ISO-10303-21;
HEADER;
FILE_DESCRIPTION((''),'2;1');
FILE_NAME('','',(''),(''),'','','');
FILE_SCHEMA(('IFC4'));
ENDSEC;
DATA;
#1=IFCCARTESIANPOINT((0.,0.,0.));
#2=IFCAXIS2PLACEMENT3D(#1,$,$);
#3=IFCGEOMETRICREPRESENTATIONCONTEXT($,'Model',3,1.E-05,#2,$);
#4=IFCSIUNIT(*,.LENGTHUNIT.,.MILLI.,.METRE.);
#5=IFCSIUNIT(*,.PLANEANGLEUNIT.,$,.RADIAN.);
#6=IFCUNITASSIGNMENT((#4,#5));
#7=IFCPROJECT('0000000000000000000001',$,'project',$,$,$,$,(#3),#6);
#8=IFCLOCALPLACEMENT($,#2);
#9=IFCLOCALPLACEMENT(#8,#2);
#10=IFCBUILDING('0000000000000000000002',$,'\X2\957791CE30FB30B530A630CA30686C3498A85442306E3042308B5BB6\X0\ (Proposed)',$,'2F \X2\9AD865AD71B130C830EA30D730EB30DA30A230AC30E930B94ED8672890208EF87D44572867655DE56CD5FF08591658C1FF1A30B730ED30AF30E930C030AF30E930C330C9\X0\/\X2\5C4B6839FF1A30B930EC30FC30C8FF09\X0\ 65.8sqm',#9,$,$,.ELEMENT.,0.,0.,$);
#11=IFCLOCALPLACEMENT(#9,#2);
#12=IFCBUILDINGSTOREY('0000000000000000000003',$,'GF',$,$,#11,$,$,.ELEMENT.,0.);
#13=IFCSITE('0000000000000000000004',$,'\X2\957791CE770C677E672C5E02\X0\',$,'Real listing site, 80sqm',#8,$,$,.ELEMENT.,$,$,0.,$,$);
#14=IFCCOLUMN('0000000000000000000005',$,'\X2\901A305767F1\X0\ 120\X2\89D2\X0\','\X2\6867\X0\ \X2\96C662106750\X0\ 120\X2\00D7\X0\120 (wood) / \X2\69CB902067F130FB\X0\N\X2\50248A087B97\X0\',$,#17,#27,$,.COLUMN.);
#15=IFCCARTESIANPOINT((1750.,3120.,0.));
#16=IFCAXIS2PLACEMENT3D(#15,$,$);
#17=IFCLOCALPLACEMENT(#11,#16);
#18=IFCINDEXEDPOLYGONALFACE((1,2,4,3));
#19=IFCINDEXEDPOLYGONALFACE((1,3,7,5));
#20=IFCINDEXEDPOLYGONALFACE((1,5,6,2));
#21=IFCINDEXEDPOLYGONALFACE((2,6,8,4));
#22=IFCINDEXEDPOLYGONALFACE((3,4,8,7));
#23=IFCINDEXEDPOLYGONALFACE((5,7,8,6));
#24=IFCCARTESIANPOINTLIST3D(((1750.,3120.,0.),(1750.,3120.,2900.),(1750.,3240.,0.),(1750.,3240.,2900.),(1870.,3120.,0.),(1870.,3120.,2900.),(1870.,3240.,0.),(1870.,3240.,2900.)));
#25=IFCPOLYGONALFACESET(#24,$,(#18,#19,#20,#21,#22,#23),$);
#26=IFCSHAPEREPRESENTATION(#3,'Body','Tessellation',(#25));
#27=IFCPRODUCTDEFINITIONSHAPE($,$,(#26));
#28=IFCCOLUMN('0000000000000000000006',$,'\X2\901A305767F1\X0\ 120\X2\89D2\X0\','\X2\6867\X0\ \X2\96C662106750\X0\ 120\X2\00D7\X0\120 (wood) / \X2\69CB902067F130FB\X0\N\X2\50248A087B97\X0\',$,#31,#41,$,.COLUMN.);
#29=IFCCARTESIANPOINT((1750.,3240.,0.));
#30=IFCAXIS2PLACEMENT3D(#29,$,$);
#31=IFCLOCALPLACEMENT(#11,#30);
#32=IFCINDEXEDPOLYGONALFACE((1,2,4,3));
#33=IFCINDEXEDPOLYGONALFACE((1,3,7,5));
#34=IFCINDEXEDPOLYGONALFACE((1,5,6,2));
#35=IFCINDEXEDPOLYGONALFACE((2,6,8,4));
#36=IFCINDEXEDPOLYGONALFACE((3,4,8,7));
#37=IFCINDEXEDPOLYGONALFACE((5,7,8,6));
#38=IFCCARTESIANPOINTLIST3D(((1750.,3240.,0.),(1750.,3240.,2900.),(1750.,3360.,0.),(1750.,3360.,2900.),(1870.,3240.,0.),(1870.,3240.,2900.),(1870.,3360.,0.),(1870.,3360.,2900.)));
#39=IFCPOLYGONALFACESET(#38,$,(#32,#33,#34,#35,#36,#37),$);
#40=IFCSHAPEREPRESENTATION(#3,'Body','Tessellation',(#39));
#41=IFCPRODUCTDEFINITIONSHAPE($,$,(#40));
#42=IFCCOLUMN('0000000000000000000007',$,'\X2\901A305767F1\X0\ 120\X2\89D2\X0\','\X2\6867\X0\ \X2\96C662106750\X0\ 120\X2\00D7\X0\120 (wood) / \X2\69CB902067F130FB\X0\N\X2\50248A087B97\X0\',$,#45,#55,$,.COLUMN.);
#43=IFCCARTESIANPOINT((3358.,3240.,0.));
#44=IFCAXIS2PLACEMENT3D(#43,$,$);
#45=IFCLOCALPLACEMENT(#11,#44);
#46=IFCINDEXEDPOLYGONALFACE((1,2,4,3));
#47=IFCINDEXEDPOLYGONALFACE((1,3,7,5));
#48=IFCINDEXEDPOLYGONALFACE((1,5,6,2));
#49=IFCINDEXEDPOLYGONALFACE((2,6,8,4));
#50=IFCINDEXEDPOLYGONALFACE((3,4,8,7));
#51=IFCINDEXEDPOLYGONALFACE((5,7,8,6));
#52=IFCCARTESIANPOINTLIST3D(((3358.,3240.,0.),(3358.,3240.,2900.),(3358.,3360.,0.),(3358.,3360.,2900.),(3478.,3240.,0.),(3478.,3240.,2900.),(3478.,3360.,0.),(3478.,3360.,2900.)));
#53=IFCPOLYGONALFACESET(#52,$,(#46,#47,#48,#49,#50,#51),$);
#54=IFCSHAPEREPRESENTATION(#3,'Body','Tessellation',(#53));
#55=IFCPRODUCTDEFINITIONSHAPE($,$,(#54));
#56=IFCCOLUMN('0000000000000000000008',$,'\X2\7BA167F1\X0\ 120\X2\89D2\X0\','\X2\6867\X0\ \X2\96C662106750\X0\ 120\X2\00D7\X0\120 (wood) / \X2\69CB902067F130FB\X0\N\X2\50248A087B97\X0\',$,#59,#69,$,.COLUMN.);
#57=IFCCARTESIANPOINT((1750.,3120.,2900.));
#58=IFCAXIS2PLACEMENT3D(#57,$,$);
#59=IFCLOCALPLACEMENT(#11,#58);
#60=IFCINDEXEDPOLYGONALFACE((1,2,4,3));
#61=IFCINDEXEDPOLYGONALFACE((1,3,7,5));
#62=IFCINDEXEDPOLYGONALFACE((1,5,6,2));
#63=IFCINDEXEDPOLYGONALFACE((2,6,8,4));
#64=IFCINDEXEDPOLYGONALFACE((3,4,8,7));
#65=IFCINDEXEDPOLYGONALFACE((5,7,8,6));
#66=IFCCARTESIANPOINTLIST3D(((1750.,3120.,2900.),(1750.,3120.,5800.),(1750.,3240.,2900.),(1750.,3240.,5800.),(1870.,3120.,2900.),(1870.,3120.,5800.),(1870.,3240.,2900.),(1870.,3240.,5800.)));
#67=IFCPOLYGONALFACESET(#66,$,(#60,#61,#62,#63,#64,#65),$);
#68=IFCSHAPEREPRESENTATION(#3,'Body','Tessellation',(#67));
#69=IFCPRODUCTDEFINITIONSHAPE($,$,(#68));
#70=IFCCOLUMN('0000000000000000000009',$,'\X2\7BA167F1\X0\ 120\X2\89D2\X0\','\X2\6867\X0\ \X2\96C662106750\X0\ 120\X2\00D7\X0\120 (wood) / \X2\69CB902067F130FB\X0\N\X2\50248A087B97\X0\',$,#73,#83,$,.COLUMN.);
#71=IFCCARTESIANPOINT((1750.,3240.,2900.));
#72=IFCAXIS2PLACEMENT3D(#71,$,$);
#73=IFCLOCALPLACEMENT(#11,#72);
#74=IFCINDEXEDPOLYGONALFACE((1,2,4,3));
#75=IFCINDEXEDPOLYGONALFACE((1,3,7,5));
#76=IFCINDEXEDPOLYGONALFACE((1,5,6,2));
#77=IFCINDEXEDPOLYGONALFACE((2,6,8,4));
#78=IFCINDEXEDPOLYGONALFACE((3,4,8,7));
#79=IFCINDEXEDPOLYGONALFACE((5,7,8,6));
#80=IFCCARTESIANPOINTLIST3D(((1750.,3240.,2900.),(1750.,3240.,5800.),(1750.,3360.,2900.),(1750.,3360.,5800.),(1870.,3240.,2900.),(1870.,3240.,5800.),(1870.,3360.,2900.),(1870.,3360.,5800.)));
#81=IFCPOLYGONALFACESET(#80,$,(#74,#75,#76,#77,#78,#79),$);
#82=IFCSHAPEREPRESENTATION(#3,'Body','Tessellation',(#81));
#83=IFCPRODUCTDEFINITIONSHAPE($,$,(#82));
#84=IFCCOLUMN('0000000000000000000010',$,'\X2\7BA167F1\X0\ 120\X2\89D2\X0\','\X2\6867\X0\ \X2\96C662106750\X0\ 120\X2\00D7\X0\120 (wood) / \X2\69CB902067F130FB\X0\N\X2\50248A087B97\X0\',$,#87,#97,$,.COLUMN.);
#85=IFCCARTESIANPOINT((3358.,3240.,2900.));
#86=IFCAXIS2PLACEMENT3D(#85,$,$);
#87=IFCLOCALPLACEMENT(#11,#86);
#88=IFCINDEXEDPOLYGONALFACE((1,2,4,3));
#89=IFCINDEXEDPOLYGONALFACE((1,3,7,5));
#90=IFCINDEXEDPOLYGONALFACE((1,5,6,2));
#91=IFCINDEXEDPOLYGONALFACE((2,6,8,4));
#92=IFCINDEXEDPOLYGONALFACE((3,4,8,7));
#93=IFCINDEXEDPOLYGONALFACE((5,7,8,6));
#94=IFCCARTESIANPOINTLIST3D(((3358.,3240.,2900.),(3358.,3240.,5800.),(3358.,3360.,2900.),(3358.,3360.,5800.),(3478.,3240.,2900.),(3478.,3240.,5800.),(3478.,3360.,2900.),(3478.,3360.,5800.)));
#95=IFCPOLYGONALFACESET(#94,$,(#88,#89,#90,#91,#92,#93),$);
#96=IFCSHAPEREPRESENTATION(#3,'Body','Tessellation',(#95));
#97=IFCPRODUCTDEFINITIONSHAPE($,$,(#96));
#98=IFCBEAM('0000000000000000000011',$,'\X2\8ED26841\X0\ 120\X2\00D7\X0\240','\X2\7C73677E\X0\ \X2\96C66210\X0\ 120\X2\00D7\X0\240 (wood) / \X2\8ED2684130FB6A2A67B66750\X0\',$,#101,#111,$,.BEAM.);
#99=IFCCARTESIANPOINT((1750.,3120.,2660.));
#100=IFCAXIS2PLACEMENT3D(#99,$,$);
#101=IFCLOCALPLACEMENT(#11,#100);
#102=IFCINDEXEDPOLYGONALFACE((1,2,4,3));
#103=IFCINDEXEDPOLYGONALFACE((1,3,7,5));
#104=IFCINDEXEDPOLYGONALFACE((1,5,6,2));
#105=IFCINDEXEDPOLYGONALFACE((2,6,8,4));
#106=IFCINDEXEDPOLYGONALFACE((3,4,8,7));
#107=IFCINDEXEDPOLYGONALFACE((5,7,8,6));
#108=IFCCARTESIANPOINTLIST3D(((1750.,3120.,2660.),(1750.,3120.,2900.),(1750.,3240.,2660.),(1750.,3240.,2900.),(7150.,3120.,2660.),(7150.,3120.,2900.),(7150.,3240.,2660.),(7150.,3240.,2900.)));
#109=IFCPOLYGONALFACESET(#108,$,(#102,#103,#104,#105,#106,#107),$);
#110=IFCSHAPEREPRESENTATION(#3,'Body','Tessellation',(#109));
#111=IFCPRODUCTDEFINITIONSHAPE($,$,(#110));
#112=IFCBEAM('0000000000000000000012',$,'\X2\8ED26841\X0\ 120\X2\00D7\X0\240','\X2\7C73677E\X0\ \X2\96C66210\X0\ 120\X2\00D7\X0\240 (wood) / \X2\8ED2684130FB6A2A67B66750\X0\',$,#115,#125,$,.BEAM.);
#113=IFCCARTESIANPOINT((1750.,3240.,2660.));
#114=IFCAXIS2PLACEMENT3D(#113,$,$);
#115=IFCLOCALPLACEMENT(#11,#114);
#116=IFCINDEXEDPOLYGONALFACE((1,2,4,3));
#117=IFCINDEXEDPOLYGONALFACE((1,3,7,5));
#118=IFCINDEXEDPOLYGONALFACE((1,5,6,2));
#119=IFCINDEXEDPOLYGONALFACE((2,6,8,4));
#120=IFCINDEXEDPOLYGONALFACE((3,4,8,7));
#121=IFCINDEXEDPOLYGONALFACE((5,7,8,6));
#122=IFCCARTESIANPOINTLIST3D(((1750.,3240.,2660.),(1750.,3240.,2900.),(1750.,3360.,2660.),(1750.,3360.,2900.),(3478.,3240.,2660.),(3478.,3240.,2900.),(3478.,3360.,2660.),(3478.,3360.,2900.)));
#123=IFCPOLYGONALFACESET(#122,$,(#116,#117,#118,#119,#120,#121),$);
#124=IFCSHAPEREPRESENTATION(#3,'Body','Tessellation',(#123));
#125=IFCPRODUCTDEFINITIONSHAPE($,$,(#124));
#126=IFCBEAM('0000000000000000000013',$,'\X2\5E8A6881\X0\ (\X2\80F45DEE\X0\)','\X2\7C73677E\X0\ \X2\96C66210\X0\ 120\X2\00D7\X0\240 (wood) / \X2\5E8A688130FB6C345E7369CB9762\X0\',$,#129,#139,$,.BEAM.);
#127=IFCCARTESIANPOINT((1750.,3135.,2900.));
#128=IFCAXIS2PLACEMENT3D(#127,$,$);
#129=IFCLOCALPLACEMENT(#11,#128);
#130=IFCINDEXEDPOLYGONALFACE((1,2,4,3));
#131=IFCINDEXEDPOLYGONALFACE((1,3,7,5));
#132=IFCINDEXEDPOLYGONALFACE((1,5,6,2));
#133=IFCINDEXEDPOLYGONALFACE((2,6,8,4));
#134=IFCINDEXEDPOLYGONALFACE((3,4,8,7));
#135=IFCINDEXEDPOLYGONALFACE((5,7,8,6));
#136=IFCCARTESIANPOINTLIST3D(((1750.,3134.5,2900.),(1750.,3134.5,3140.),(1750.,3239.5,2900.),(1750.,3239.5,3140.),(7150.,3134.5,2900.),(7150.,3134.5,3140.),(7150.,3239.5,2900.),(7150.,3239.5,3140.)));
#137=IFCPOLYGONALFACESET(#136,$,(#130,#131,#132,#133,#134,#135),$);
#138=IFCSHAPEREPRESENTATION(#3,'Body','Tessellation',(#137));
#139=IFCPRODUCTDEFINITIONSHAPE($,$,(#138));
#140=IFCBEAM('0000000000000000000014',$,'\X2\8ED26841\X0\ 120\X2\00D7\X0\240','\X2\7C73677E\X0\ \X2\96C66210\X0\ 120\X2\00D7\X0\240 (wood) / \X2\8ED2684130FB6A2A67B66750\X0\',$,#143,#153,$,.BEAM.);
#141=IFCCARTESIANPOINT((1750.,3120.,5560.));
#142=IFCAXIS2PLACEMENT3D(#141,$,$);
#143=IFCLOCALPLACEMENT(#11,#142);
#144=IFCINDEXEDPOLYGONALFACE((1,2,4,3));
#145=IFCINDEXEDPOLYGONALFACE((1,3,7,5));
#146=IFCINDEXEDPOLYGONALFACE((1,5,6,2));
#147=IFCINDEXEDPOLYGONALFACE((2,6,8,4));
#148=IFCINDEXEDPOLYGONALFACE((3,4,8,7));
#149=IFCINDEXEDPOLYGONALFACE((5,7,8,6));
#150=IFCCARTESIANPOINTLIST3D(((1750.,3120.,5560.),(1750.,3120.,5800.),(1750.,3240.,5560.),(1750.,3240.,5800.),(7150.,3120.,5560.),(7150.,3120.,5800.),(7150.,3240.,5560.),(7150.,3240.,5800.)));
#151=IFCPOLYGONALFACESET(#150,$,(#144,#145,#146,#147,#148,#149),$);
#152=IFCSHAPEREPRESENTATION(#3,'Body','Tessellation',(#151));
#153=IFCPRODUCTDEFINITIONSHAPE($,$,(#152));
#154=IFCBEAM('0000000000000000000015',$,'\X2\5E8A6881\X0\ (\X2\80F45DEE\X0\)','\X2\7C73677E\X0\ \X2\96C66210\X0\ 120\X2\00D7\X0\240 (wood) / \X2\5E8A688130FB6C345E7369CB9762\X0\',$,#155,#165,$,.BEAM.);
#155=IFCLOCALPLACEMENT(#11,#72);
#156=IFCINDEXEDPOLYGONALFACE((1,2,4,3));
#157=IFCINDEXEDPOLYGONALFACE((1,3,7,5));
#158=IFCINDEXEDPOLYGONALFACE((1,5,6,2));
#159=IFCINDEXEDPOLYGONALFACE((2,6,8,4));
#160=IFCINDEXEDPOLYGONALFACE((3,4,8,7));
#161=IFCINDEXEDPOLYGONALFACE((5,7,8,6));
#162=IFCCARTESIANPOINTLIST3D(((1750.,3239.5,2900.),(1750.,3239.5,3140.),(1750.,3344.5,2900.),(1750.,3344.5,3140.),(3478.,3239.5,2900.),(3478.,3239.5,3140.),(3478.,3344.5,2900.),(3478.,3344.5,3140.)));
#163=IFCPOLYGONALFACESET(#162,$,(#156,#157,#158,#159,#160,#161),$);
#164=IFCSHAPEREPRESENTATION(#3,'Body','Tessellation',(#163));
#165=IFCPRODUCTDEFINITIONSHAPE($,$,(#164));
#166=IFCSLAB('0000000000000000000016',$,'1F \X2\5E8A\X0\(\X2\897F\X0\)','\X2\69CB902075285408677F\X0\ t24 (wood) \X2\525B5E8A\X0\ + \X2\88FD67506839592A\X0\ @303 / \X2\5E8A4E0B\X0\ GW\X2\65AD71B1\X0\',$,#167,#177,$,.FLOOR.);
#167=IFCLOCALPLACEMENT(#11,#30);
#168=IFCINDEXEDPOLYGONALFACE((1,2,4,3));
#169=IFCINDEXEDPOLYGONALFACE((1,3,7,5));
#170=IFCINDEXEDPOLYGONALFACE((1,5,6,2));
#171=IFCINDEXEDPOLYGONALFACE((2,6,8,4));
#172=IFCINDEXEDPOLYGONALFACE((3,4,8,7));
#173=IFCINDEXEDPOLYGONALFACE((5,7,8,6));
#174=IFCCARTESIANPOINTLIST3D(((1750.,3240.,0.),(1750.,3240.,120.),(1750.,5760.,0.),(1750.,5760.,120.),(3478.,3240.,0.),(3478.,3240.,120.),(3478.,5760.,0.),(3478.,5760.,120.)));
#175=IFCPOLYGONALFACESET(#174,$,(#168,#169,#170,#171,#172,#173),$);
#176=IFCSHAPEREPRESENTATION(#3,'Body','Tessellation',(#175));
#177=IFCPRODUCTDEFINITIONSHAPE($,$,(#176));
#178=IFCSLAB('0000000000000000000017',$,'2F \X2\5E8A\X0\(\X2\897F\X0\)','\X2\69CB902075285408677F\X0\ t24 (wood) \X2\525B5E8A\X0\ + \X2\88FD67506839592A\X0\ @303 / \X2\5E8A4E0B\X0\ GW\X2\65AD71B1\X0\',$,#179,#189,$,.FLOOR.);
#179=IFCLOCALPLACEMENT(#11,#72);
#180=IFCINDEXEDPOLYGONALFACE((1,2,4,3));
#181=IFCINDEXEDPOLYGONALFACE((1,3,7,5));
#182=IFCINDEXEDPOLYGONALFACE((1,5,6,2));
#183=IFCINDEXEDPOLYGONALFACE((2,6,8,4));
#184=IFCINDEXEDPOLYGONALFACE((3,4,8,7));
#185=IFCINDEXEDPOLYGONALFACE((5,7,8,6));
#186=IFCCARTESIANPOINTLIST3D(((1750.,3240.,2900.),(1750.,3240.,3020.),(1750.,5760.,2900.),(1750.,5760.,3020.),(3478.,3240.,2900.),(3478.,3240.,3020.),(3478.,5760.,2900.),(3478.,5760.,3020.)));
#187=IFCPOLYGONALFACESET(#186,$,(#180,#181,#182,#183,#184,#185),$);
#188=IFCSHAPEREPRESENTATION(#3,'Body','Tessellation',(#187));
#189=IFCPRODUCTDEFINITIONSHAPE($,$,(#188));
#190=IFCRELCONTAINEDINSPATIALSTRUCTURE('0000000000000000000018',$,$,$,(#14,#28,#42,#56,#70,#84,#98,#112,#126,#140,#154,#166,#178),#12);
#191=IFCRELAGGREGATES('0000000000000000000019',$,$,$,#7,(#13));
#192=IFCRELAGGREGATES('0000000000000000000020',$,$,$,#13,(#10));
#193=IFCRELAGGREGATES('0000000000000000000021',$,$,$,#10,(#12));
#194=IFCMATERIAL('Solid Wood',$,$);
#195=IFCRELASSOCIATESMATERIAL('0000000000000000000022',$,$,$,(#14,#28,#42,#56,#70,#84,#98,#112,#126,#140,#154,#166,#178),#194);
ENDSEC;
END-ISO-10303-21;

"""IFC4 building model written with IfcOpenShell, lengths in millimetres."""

from ifc_helpers import new_model, si_unit, frame, frame_2d, origin, place, context, project, spatial, rectangle, extrude, material, element, save


model = new_model("IFC4")

# Units and contexts
model_context = context("Model", 3, precision=1e-05, world=origin())
ifc_project = project(units=[si_unit("LENGTHUNIT", "METRE", prefix="MILLI"), si_unit("PLANEANGLEUNIT", "RADIAN")], contexts=[model_context])

# Site, building, storey
site_placement = place(None, origin())
site = spatial("IfcSite", under=ifc_project, at=site_placement, Name="長野県松本市", ObjectType="Real listing site, 80sqm", CompositionType="ELEMENT", RefElevation=0.0)
building_placement = place(site_placement, origin())
building = spatial("IfcBuilding", under=site, at=building_placement, Name="長野・サウナと水風呂のある家 (Proposed)", ObjectType="2F 高断熱トリプルペアガラス付木造軸組在来工法（外壁：シロクラダクラッド/屋根：スレート） 65.8sqm", CompositionType="ELEMENT", ElevationOfRefHeight=0.0, ElevationOfTerrain=0.0)
storey_placement = place(building_placement, origin())
storey = spatial("IfcBuildingStorey", under=building, at=storey_placement, Name="GF", CompositionType="ELEMENT", Elevation=0.0)

# Columns
ifc_material_1 = material(Name="Solid Wood")
column_1_placement = place(storey_placement, frame((1750.0, 3120.0, 0.0)))
element("IfcColumn", 1, at=column_1_placement, inside=storey, material=ifc_material_1, Name="通し柱 120角", Description="桧 集成材 120×120 (wood) / 構造柱・N値計算", PredefinedType="COLUMN", context=model_context, shape_type="SweptSolid", body=[
    extrude(rectangle(XDim=120.0, YDim=120.0, at=frame_2d((60.0, 60.0))), frame((1750.0, 3120.0, 0.0)), (0.0, 0.0, 1.0), 2900.0),
])
column_2_placement = place(storey_placement, frame((1750.0, 3240.0, 0.0)))
element("IfcColumn", 2, at=column_2_placement, inside=storey, material=ifc_material_1, Name="通し柱 120角", Description="桧 集成材 120×120 (wood) / 構造柱・N値計算", PredefinedType="COLUMN", context=model_context, shape_type="SweptSolid", body=[
    extrude(rectangle(XDim=120.0, YDim=120.0, at=frame_2d((60.0, 60.0))), frame((1750.0, 3240.0, 0.0)), (0.0, 0.0, 1.0), 2900.0),
])
column_3_placement = place(storey_placement, frame((3358.0, 3240.0, 0.0)))
element("IfcColumn", 3, at=column_3_placement, inside=storey, material=ifc_material_1, Name="通し柱 120角", Description="桧 集成材 120×120 (wood) / 構造柱・N値計算", PredefinedType="COLUMN", context=model_context, shape_type="SweptSolid", body=[
    extrude(rectangle(XDim=120.0, YDim=120.0, at=frame_2d((60.0, 60.0))), frame((3358.0, 3240.0, 0.0)), (0.0, 0.0, 1.0), 2900.0),
])
column_4_placement = place(storey_placement, frame((1750.0, 3120.0, 2900.0)))
element("IfcColumn", 4, at=column_4_placement, inside=storey, material=ifc_material_1, Name="管柱 120角", Description="桧 集成材 120×120 (wood) / 構造柱・N値計算", PredefinedType="COLUMN", context=model_context, shape_type="SweptSolid", body=[
    extrude(rectangle(XDim=120.0, YDim=120.0, at=frame_2d((60.0, 60.0))), frame((1750.0, 3120.0, 2900.0)), (0.0, 0.0, 1.0), 2900.0),
])
column_5_placement = place(storey_placement, frame((1750.0, 3240.0, 2900.0)))
element("IfcColumn", 5, at=column_5_placement, inside=storey, material=ifc_material_1, Name="管柱 120角", Description="桧 集成材 120×120 (wood) / 構造柱・N値計算", PredefinedType="COLUMN", context=model_context, shape_type="SweptSolid", body=[
    extrude(rectangle(XDim=120.0, YDim=120.0, at=frame_2d((60.0, 60.0))), frame((1750.0, 3240.0, 2900.0)), (0.0, 0.0, 1.0), 2900.0),
])
column_6_placement = place(storey_placement, frame((3358.0, 3240.0, 2900.0)))
element("IfcColumn", 6, at=column_6_placement, inside=storey, material=ifc_material_1, Name="管柱 120角", Description="桧 集成材 120×120 (wood) / 構造柱・N値計算", PredefinedType="COLUMN", context=model_context, shape_type="SweptSolid", body=[
    extrude(rectangle(XDim=120.0, YDim=120.0, at=frame_2d((60.0, 60.0))), frame((3358.0, 3240.0, 2900.0)), (0.0, 0.0, 1.0), 2900.0),
])

# Beams
beam_1_placement = place(storey_placement, frame((1750.0, 3120.0, 2660.0)))
element("IfcBeam", 7, at=beam_1_placement, inside=storey, material=ifc_material_1, Name="軒桁 120×240", Description="米松 集成 120×240 (wood) / 軒桁・横架材", PredefinedType="BEAM", context=model_context, shape_type="SweptSolid", body=[
    extrude(rectangle(XDim=5400.0, YDim=120.0, at=frame_2d((2700.0, 60.0))), frame((1750.0, 3120.0, 2660.0)), (0.0, 0.0, 1.0), 240.0),
])
beam_2_placement = place(storey_placement, frame((1750.0, 3240.0, 2660.0)))
element("IfcBeam", 8, at=beam_2_placement, inside=storey, material=ifc_material_1, Name="軒桁 120×240", Description="米松 集成 120×240 (wood) / 軒桁・横架材", PredefinedType="BEAM", context=model_context, shape_type="SweptSolid", body=[
    extrude(rectangle(XDim=1728.0, YDim=120.0, at=frame_2d((864.0, 60.0))), frame((1750.0, 3240.0, 2660.0)), (0.0, 0.0, 1.0), 240.0),
])
beam_3_placement = place(storey_placement, frame((1750.0, 3135.0, 2900.0)))
element("IfcBeam", 9, at=beam_3_placement, inside=storey, material=ifc_material_1, Name="床梁 (胴差)", Description="米松 集成 120×240 (wood) / 床梁・水平構面", PredefinedType="BEAM", context=model_context, shape_type="SweptSolid", body=[
    extrude(rectangle(XDim=5400.0, YDim=105.0, at=frame_2d((2700.0, 52.0))), frame((1750.0, 3135.0, 2900.0)), (0.0, 0.0, 1.0), 240.0),
])
beam_4_placement = place(storey_placement, frame((1750.0, 3120.0, 5560.0)))
element("IfcBeam", 10, at=beam_4_placement, inside=storey, material=ifc_material_1, Name="軒桁 120×240", Description="米松 集成 120×240 (wood) / 軒桁・横架材", PredefinedType="BEAM", context=model_context, shape_type="SweptSolid", body=[
    extrude(rectangle(XDim=5400.0, YDim=120.0, at=frame_2d((2700.0, 60.0))), frame((1750.0, 3120.0, 5560.0)), (0.0, 0.0, 1.0), 240.0),
])
beam_5_placement = place(storey_placement, frame((1750.0, 3240.0, 2900.0)))
element("IfcBeam", 11, at=beam_5_placement, inside=storey, material=ifc_material_1, Name="床梁 (胴差)", Description="米松 集成 120×240 (wood) / 床梁・水平構面", PredefinedType="BEAM", context=model_context, shape_type="SweptSolid", body=[
    extrude(rectangle(XDim=1728.0, YDim=105.0, at=frame_2d((864.0, 52.0))), frame((1750.0, 3240.0, 2900.0)), (0.0, 0.0, 1.0), 240.0),
])

# Slabs
slab_1_placement = place(storey_placement, frame((1750.0, 3240.0, 0.0)))
element("IfcSlab", 12, at=slab_1_placement, inside=storey, material=ifc_material_1, Name="1F 床(西)", Description="構造用合板 t24 (wood) 剛床 + 製材根太 @303 / 床下 GW断熱", PredefinedType="FLOOR", context=model_context, shape_type="SweptSolid", body=[
    extrude(rectangle(XDim=1728.0, YDim=2520.0, at=frame_2d((864.0, 1260.0))), frame((1750.0, 3240.0, 0.0)), (0.0, 0.0, 1.0), 120.0),
])
slab_2_placement = place(storey_placement, frame((1750.0, 3240.0, 2900.0)))
element("IfcSlab", 13, at=slab_2_placement, inside=storey, material=ifc_material_1, Name="2F 床(西)", Description="構造用合板 t24 (wood) 剛床 + 製材根太 @303 / 床下 GW断熱", PredefinedType="FLOOR", context=model_context, shape_type="SweptSolid", body=[
    extrude(rectangle(XDim=1728.0, YDim=2520.0, at=frame_2d((864.0, 1260.0))), frame((1750.0, 3240.0, 2900.0)), (0.0, 0.0, 1.0), 120.0),
])

save(model, "model.ifc")
